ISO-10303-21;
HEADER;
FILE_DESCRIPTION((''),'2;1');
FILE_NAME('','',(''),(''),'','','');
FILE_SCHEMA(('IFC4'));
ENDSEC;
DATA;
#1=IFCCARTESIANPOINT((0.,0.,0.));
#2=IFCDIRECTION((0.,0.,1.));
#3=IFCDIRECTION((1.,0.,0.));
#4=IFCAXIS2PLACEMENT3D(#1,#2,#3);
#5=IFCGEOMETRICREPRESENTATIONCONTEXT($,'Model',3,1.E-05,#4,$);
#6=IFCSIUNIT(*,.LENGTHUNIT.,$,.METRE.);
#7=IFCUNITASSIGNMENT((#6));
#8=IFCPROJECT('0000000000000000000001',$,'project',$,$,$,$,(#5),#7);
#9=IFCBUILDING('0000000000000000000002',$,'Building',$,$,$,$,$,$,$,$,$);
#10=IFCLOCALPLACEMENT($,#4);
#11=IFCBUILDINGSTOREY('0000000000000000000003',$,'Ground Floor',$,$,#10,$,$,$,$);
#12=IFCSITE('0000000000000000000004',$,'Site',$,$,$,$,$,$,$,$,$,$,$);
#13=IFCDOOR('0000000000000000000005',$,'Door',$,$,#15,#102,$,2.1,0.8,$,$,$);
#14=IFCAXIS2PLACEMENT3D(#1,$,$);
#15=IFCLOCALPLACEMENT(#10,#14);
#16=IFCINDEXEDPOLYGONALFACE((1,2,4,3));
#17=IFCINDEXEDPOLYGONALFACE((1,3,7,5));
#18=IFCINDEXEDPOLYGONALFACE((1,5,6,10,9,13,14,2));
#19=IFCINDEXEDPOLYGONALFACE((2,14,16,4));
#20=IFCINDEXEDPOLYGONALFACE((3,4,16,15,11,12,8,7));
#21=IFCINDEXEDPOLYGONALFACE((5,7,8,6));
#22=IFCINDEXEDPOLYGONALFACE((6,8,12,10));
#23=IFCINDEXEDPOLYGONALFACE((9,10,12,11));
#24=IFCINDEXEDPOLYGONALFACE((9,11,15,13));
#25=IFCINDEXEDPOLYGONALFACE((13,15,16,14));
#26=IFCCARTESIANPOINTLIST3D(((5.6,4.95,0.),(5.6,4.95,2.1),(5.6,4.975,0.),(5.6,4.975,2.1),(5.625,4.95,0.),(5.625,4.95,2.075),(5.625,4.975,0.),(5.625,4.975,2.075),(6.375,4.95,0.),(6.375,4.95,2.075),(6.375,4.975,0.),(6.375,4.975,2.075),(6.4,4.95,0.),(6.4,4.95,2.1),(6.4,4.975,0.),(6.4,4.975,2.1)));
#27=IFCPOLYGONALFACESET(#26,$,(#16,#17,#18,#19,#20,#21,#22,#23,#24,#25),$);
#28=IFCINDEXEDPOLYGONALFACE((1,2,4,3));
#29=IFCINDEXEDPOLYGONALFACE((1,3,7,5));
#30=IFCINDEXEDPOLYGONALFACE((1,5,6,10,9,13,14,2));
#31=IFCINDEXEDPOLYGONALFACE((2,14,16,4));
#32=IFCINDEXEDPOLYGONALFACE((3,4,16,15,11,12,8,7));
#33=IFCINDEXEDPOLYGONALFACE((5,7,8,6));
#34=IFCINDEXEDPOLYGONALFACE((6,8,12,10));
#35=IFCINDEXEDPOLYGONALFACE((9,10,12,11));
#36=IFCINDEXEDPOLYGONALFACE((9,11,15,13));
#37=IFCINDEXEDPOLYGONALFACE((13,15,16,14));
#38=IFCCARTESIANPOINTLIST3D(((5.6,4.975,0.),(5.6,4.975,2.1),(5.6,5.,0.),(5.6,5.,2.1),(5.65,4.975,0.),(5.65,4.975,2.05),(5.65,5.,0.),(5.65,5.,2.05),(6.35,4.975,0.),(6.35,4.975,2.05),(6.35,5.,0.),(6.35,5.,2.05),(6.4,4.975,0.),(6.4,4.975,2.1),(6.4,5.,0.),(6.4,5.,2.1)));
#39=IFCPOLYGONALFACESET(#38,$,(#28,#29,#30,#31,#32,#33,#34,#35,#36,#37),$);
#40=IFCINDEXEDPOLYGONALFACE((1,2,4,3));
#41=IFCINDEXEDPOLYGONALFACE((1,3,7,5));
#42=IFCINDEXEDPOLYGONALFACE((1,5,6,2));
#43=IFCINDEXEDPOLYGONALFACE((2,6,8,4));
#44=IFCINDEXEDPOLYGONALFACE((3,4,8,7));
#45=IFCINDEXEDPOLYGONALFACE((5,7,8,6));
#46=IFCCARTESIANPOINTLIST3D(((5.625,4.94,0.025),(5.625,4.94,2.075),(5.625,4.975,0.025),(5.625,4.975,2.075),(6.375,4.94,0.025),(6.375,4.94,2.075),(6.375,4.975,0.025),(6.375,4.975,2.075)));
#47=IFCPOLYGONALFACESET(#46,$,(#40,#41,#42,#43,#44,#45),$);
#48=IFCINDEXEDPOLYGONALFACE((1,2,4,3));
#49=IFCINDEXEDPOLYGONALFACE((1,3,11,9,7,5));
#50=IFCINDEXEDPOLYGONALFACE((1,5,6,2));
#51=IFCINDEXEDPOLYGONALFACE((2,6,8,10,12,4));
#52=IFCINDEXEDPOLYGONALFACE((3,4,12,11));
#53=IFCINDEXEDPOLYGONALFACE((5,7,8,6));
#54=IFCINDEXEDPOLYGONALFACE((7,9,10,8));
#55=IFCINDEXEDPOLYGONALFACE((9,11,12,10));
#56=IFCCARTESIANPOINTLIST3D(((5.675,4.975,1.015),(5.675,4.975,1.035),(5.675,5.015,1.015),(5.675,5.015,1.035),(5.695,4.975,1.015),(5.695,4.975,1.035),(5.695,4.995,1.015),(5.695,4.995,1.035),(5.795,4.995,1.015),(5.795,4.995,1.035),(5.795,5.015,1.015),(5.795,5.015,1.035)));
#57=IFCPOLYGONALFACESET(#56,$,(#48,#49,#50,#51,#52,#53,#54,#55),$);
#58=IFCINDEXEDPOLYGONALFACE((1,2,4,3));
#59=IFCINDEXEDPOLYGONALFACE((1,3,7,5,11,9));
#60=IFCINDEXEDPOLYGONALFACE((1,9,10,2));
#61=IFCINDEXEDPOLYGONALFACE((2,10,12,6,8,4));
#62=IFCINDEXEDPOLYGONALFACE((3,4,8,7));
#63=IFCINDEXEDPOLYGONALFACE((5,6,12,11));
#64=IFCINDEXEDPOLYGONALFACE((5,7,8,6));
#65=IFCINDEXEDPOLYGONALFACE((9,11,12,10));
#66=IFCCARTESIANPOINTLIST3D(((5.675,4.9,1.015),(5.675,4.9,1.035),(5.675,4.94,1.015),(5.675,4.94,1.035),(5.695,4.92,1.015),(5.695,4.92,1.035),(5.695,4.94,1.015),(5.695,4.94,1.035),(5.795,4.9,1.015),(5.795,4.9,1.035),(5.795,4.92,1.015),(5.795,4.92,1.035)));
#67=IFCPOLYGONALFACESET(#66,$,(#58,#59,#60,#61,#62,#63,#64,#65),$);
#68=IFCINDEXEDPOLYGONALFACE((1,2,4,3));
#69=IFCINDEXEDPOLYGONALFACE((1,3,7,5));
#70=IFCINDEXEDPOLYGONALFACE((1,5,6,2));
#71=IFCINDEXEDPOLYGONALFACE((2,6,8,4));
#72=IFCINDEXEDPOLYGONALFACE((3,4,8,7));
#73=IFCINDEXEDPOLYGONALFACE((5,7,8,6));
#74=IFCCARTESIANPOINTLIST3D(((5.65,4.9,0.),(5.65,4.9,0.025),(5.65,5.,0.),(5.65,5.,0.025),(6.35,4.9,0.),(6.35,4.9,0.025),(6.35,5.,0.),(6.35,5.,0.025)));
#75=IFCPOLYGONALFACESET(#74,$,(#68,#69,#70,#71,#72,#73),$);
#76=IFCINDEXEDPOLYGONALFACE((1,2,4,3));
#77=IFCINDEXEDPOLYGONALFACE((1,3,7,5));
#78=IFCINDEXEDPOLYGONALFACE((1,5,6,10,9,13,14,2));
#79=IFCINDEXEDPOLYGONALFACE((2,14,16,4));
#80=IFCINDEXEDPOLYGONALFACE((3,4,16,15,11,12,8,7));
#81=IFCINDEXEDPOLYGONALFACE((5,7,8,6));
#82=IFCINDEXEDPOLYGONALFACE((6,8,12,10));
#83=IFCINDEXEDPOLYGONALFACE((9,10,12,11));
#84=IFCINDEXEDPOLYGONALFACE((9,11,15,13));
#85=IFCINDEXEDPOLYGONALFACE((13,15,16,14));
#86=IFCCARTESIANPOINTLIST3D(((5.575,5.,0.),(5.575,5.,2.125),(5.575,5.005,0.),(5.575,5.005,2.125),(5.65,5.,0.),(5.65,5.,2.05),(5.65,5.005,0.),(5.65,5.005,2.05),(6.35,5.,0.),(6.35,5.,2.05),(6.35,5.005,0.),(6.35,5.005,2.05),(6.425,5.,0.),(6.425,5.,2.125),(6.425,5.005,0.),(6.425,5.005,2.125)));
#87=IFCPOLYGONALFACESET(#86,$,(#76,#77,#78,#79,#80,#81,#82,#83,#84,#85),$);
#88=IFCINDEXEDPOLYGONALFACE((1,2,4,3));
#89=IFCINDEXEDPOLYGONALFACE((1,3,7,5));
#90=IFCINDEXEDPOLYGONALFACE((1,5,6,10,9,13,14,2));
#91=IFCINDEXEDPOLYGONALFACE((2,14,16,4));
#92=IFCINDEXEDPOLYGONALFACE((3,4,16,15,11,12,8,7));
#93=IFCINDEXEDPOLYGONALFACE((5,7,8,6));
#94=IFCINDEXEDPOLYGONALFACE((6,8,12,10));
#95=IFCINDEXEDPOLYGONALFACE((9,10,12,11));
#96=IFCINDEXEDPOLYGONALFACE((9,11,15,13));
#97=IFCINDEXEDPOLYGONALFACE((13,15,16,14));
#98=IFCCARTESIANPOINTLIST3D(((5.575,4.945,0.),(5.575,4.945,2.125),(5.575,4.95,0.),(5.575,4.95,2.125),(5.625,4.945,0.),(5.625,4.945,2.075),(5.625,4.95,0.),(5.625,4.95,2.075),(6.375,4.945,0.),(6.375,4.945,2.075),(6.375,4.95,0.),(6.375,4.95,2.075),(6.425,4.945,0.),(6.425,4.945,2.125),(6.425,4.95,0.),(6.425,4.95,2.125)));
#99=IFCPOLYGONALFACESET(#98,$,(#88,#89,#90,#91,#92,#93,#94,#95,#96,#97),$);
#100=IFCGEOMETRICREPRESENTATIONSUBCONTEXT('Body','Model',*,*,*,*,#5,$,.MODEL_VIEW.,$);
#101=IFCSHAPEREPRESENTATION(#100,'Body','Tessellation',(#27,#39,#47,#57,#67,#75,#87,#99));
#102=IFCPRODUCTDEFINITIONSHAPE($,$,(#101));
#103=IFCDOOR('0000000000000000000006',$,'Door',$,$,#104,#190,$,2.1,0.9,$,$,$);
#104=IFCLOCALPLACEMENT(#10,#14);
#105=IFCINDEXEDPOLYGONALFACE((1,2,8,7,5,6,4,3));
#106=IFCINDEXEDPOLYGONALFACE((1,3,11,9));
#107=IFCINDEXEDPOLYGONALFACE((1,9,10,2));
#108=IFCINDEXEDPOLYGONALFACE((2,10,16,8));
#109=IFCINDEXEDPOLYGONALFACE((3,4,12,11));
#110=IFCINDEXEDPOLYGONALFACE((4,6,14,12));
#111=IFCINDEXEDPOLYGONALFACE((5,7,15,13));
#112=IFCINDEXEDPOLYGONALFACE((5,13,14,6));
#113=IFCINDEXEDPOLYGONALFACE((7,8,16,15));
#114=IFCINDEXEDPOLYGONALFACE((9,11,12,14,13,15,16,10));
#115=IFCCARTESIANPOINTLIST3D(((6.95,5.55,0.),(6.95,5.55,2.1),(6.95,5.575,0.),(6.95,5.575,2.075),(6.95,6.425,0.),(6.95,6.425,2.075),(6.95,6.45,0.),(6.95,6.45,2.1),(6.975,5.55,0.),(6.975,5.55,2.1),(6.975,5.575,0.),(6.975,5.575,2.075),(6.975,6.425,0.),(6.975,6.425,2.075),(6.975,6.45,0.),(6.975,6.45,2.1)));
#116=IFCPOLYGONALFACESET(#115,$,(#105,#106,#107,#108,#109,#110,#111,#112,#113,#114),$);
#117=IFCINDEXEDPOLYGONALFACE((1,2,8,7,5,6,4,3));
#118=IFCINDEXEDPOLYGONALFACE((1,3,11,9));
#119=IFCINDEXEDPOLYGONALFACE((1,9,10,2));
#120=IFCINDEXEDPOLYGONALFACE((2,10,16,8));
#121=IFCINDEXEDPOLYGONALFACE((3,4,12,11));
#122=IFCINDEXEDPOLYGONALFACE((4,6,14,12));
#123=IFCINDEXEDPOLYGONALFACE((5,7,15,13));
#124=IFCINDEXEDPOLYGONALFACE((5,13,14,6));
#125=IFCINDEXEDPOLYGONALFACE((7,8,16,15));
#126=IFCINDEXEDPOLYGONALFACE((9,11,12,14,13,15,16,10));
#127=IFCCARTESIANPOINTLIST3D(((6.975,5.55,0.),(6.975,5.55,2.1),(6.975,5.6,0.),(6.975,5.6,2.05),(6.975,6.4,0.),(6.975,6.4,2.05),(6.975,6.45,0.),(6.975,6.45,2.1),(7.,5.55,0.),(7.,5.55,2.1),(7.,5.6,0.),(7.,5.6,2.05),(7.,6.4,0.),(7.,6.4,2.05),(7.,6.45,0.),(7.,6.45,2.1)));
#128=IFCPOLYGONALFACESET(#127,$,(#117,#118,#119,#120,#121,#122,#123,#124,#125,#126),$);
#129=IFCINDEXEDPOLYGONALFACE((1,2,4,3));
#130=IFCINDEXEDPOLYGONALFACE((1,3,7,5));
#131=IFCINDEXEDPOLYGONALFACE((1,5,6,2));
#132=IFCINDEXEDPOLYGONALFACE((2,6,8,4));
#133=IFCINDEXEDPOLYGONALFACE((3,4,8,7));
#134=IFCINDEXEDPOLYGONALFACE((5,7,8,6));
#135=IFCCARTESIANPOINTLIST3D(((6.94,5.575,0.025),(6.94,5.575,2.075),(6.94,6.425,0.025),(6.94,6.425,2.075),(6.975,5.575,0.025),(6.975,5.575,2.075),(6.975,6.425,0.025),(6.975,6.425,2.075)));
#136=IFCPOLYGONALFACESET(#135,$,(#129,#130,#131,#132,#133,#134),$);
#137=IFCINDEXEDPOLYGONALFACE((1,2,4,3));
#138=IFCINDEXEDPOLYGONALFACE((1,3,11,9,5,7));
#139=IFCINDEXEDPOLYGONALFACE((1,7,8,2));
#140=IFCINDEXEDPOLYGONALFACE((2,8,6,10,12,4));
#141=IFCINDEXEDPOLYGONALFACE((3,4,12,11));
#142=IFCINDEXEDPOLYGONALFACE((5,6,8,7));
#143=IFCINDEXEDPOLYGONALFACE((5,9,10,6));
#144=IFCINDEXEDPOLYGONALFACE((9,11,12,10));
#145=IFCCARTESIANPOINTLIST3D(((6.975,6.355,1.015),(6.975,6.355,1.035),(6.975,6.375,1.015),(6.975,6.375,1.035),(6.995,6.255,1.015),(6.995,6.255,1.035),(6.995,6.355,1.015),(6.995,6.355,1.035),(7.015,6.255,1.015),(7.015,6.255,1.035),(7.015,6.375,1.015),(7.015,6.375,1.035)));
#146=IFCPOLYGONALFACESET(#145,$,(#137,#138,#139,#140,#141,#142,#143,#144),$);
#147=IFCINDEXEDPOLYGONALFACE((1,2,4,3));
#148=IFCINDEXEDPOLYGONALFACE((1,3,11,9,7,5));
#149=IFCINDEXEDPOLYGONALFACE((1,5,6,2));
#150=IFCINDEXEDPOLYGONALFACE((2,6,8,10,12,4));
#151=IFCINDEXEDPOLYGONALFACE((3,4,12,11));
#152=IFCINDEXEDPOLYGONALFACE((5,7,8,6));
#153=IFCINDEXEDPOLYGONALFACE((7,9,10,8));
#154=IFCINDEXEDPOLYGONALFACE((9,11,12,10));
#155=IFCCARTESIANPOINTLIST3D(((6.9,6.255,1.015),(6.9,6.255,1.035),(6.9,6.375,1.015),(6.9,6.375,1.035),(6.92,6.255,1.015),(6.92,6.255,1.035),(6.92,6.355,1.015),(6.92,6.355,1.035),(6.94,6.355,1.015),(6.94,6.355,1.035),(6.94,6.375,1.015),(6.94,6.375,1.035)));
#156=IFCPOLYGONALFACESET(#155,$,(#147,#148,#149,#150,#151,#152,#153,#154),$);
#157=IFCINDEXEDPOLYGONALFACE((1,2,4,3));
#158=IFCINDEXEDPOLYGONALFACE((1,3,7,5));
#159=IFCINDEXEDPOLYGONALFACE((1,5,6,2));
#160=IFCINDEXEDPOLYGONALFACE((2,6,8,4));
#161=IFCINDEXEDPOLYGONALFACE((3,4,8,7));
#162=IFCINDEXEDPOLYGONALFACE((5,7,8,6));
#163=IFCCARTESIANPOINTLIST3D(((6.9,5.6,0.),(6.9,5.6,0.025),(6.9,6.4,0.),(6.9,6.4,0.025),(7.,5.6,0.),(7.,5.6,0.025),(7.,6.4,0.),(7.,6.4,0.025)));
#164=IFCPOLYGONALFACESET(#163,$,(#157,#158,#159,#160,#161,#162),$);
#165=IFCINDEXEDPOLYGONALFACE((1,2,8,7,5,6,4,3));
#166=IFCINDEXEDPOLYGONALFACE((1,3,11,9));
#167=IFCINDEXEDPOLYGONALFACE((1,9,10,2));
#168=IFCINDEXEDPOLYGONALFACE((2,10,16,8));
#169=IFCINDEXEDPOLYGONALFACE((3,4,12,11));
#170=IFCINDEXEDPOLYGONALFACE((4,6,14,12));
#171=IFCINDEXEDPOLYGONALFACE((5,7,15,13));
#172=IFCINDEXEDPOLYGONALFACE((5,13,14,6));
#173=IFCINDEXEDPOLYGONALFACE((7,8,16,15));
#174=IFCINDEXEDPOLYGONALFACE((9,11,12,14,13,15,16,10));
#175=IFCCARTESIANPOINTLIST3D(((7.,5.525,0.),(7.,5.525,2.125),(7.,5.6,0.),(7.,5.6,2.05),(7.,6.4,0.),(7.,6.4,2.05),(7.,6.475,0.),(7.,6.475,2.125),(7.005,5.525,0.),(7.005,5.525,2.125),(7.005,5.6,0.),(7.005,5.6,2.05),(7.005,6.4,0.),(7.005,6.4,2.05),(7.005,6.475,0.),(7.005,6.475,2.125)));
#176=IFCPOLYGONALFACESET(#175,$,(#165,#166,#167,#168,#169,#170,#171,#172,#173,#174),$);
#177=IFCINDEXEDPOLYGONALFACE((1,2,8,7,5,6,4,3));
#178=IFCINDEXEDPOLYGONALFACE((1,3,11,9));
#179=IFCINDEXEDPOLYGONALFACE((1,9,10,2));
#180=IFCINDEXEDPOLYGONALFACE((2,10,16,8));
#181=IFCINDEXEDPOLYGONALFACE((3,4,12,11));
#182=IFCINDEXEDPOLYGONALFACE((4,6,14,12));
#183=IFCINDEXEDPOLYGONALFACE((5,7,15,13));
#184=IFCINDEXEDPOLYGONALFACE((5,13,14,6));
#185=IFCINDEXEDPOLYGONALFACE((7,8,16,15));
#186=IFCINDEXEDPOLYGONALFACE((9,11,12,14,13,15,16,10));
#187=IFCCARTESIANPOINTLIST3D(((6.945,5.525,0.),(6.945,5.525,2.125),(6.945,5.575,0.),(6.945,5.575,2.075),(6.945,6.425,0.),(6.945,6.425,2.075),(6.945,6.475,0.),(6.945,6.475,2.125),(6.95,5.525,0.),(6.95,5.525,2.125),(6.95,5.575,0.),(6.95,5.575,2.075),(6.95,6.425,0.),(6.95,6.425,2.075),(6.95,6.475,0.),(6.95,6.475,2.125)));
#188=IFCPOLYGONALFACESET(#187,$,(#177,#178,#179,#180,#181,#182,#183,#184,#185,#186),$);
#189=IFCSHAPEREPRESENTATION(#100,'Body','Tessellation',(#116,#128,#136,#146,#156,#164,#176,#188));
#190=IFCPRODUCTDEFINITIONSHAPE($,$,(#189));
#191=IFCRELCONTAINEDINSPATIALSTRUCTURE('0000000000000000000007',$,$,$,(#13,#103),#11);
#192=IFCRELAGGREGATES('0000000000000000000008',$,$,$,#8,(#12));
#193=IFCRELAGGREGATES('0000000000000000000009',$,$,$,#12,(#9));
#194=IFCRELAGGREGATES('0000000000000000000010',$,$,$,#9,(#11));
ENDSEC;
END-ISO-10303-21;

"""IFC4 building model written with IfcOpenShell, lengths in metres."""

from ifc_helpers import new_model, si_unit, frame, origin_with_axes, place, context, subcontext, project, spatial, line, indexed_curve, outline, extrude, element, save


model = new_model("IFC4")

# Units and contexts
model_context = context("Model", 3, precision=1e-05, world=origin_with_axes())
body_context = subcontext(model_context, "Body", "Model", "MODEL_VIEW")
ifc_project = project(units=[si_unit("LENGTHUNIT", "METRE")], contexts=[model_context])

# Site, building, storey
site = spatial("IfcSite", under=ifc_project, Name="Site")
building = spatial("IfcBuilding", under=site, Name="Building")
storey_placement = place(None, origin_with_axes())
storey = spatial("IfcBuildingStorey", under=building, at=storey_placement, Name="Ground Floor")

# Doors
door_1_placement = place(storey_placement, frame((6.4, 5.0, 0.0), z_axis=(0.0, 0.0, 1.0), x_axis=(-1.0, 0.0, 0.0)))
element("IfcDoor", 1, at=door_1_placement, inside=storey, Name="Door", OverallHeight=2.1, OverallWidth=0.8, context=body_context, shape_type="SweptSolid", body=[
    extrude(outline(indexed_curve([(0.0, 0.0), (0.0, 2.1), (0.8, 2.1), (0.8, 0.0), (0.775, 0.0), (0.775, 2.075), (0.025, 2.075), (0.025, 0.0)], segments=[line(1, 2, 3, 4, 5, 6, 7, 8, 1)])), frame((0.0, 0.025, 0.0), z_axis=(0.0, -1.0, 0.0), x_axis=(1.0, 0.0, 0.0)), (0.0, 0.0, -1.0), 0.025),
    extrude(outline(indexed_curve([(0.0, 0.0), (0.0, 2.1), (0.8, 2.1), (0.8, 0.0), (0.75, 0.0), (0.75, 2.05), (0.05, 2.05), (0.05, 0.0)], segments=[line(1, 2, 3, 4, 5, 6, 7, 8, 1)])), frame((0.0, 0.0, 0.0), z_axis=(0.0, -1.0, 0.0), x_axis=(1.0, 0.0, 0.0)), (0.0, 0.0, -1.0), 0.025),
    extrude(outline(indexed_curve([(0.0, 0.0), (0.75, 0.0), (0.75, 0.035), (0.0, 0.035)], segments=[line(1, 2, 3, 4, 1)])), frame((0.025, 0.025, 0.025), z_axis=(0.0, 0.0, 1.0), x_axis=(1.0, 0.0, 0.0)), (0.0, 0.0, 1.0), 2.05),
    extrude(outline(indexed_curve([(0.0, 0.0), (0.0, -0.04), (-0.12, -0.04), (-0.12, -0.02), (-0.02, -0.02), (-0.02, 0.0)], segments=[line(1, 2, 3, 4, 5, 6, 1)])), frame((0.725, 0.025, 1.015), z_axis=(0.0, 0.0, 1.0), x_axis=(1.0, 0.0, 0.0)), (0.0, 0.0, 1.0), 0.02),
    extrude(outline(indexed_curve([(0.0, 0.0), (0.0, 0.04), (-0.12, 0.04), (-0.12, 0.02), (-0.02, 0.02), (-0.02, 0.0)], segments=[line(1, 2, 3, 4, 5, 6, 1)])), frame((0.725, 0.06, 1.015), z_axis=(0.0, 0.0, 1.0), x_axis=(1.0, 0.0, 0.0)), (0.0, 0.0, 1.0), 0.02),
    extrude(outline(indexed_curve([(0.0, 0.0), (0.7, 0.0), (0.7, 0.1), (0.0, 0.1)], segments=[line(1, 2, 3, 4, 1)])), frame((0.05, 0.0, 0.0), z_axis=(0.0, 0.0, 1.0), x_axis=(1.0, 0.0, 0.0)), (0.0, 0.0, 1.0), 0.025),
    extrude(outline(indexed_curve([(0.0, 0.0), (0.0, 2.125), (0.85, 2.125), (0.85, 0.0), (0.775, 0.0), (0.775, 2.05), (0.075, 2.05), (0.075, 0.0)], segments=[line(1, 2, 3, 4, 5, 6, 7, 8, 1)])), frame((-0.025, -0.005, 0.0), z_axis=(0.0, -1.0, 0.0), x_axis=(1.0, 0.0, 0.0)), (0.0, 0.0, -1.0), 0.005),
    extrude(outline(indexed_curve([(0.0, 0.0), (0.0, 2.125), (0.85, 2.125), (0.85, 0.0), (0.8, 0.0), (0.8, 2.075), (0.05, 2.075), (0.05, 0.0)], segments=[line(1, 2, 3, 4, 5, 6, 7, 8, 1)])), frame((-0.025, 0.05, 0.0), z_axis=(0.0, -1.0, 0.0), x_axis=(1.0, 0.0, 0.0)), (0.0, 0.0, -1.0), 0.005),
])
door_2_placement = place(storey_placement, frame((7.0, 5.55, 0.0), z_axis=(0.0, 0.0, 1.0), x_axis=(0.0, 1.0, 0.0)))
element("IfcDoor", 2, at=door_2_placement, inside=storey, Name="Door", OverallHeight=2.1, OverallWidth=0.9, context=body_context, shape_type="SweptSolid", body=[
    extrude(outline(indexed_curve([(0.0, 0.0), (0.0, 2.1), (0.9, 2.1), (0.9, 0.0), (0.875, 0.0), (0.875, 2.075), (0.025, 2.075), (0.025, 0.0)], segments=[line(1, 2, 3, 4, 5, 6, 7, 8, 1)])), frame((0.0, 0.025, 0.0), z_axis=(0.0, -1.0, 0.0), x_axis=(1.0, 0.0, 0.0)), (0.0, 0.0, -1.0), 0.025),
    extrude(outline(indexed_curve([(0.0, 0.0), (0.0, 2.1), (0.9, 2.1), (0.9, 0.0), (0.85, 0.0), (0.85, 2.05), (0.05, 2.05), (0.05, 0.0)], segments=[line(1, 2, 3, 4, 5, 6, 7, 8, 1)])), frame((0.0, 0.0, 0.0), z_axis=(0.0, -1.0, 0.0), x_axis=(1.0, 0.0, 0.0)), (0.0, 0.0, -1.0), 0.025),
    extrude(outline(indexed_curve([(0.0, 0.0), (0.85, 0.0), (0.85, 0.035), (0.0, 0.035)], segments=[line(1, 2, 3, 4, 1)])), frame((0.025, 0.025, 0.025), z_axis=(0.0, 0.0, 1.0), x_axis=(1.0, 0.0, 0.0)), (0.0, 0.0, 1.0), 2.05),
    extrude(outline(indexed_curve([(0.0, 0.0), (0.0, -0.04), (-0.12, -0.04), (-0.12, -0.02), (-0.02, -0.02), (-0.02, 0.0)], segments=[line(1, 2, 3, 4, 5, 6, 1)])), frame((0.825, 0.025, 1.015), z_axis=(0.0, 0.0, 1.0), x_axis=(1.0, 0.0, 0.0)), (0.0, 0.0, 1.0), 0.02),
    extrude(outline(indexed_curve([(0.0, 0.0), (0.0, 0.04), (-0.12, 0.04), (-0.12, 0.02), (-0.02, 0.02), (-0.02, 0.0)], segments=[line(1, 2, 3, 4, 5, 6, 1)])), frame((0.825, 0.06, 1.015), z_axis=(0.0, 0.0, 1.0), x_axis=(1.0, 0.0, 0.0)), (0.0, 0.0, 1.0), 0.02),
    extrude(outline(indexed_curve([(0.0, 0.0), (0.8, 0.0), (0.8, 0.1), (0.0, 0.1)], segments=[line(1, 2, 3, 4, 1)])), frame((0.05, 0.0, 0.0), z_axis=(0.0, 0.0, 1.0), x_axis=(1.0, 0.0, 0.0)), (0.0, 0.0, 1.0), 0.025),
    extrude(outline(indexed_curve([(0.0, 0.0), (0.0, 2.125), (0.95, 2.125), (0.95, 0.0), (0.875, 0.0), (0.875, 2.05), (0.075, 2.05), (0.075, 0.0)], segments=[line(1, 2, 3, 4, 5, 6, 7, 8, 1)])), frame((-0.025, -0.005, 0.0), z_axis=(0.0, -1.0, 0.0), x_axis=(1.0, 0.0, 0.0)), (0.0, 0.0, -1.0), 0.005),
    extrude(outline(indexed_curve([(0.0, 0.0), (0.0, 2.125), (0.95, 2.125), (0.95, 0.0), (0.9, 0.0), (0.9, 2.075), (0.05, 2.075), (0.05, 0.0)], segments=[line(1, 2, 3, 4, 5, 6, 7, 8, 1)])), frame((-0.025, 0.05, 0.0), z_axis=(0.0, -1.0, 0.0), x_axis=(1.0, 0.0, 0.0)), (0.0, 0.0, -1.0), 0.005),
])

save(model, "model.ifc")
